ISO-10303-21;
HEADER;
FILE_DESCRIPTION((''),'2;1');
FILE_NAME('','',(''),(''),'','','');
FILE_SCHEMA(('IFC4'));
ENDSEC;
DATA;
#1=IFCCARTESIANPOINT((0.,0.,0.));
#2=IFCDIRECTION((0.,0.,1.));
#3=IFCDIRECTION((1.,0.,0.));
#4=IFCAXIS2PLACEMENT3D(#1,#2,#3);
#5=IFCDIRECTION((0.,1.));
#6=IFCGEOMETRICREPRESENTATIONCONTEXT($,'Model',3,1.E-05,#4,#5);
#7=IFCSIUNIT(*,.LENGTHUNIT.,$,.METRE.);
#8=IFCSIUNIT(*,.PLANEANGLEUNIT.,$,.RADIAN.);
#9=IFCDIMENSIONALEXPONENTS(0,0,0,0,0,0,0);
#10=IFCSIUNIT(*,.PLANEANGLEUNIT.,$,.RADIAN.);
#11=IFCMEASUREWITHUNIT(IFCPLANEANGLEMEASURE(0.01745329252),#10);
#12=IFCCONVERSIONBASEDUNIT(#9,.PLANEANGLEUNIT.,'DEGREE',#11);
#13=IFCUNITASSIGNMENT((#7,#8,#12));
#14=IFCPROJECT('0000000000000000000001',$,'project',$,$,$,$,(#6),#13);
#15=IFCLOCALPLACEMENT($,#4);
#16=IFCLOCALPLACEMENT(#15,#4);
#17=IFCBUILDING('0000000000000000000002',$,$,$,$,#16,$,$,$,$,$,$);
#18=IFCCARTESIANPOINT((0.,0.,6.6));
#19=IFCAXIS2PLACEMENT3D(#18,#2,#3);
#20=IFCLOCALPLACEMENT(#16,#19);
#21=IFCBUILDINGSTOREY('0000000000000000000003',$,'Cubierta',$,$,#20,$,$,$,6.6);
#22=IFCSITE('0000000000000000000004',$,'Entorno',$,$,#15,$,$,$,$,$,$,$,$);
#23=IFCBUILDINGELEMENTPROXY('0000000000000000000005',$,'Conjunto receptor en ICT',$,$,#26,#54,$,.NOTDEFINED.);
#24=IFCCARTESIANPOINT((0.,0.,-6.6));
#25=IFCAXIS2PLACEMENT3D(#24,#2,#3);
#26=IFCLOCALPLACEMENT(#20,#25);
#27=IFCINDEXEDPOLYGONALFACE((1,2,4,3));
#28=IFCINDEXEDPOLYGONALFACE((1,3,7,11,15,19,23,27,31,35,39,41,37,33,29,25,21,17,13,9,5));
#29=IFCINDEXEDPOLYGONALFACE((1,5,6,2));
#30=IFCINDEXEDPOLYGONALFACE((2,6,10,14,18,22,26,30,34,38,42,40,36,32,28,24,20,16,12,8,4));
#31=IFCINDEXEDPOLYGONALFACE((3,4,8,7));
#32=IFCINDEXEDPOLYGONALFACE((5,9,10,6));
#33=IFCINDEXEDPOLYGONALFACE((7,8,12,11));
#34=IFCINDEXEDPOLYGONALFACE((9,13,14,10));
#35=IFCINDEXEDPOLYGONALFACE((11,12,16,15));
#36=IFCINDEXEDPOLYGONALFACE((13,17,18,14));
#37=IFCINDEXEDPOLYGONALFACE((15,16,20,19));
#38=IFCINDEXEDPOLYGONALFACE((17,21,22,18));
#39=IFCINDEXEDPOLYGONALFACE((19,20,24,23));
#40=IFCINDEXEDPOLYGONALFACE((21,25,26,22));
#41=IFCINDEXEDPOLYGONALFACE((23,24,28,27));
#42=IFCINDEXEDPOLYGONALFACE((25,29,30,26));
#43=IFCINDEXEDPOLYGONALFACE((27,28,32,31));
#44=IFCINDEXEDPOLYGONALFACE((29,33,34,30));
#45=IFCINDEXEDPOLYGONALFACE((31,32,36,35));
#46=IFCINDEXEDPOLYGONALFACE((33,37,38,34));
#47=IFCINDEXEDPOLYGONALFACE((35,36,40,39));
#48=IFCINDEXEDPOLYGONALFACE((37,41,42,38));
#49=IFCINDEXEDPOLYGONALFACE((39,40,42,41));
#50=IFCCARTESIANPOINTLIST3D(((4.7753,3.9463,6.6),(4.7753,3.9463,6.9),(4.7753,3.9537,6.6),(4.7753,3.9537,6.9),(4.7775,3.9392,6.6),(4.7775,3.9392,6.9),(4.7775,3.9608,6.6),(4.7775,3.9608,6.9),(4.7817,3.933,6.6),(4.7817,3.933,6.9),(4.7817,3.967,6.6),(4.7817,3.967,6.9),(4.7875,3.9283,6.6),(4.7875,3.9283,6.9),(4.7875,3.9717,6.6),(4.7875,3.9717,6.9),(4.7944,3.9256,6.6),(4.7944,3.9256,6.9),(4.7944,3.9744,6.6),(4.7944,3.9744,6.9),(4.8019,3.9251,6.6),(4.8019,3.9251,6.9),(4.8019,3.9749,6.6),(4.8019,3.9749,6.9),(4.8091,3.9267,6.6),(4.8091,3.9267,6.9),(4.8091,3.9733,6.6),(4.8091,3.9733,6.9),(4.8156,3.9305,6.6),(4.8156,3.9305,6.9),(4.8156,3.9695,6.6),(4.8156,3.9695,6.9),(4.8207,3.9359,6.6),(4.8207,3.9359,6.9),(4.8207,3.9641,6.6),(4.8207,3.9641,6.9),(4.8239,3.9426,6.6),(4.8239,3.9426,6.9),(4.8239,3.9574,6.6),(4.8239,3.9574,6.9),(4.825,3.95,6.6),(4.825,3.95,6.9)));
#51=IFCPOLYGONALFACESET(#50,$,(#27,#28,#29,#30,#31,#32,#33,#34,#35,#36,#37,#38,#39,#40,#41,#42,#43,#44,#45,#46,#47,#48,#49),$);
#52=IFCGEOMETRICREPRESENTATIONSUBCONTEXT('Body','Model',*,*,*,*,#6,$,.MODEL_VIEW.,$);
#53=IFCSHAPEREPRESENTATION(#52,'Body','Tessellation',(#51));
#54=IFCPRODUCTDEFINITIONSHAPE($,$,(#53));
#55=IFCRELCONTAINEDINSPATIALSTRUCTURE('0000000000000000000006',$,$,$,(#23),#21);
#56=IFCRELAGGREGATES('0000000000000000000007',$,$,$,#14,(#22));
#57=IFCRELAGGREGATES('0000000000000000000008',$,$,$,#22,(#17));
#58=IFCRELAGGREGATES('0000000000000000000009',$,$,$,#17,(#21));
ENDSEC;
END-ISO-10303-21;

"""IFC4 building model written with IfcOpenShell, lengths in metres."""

from ifc_helpers import new_model, entity, si_unit, converted_unit, direction, frame, origin_with_axes, place, context, subcontext, project, spatial, element, save


model = new_model("IFC4")

# Units and contexts
model_context = context("Model", 3, precision=1e-05, world=origin_with_axes(), true_north=direction((0.0, 1.0)))
body_context = subcontext(model_context, "Body", "Model", "MODEL_VIEW")
ifc_project = project(units=[si_unit("LENGTHUNIT", "METRE"), si_unit("PLANEANGLEUNIT", "RADIAN"), converted_unit("PLANEANGLEUNIT", "DEGREE", entity("IfcPlaneAngleMeasure", 0.01745329252), si_unit("PLANEANGLEUNIT", "RADIAN"), dimensions=[0, 0, 0, 0, 0, 0, 0])], contexts=[model_context])

# Site, building, storey
site_placement = place(None, origin_with_axes())
site = spatial("IfcSite", under=ifc_project, at=site_placement, Name="Entorno")
building_placement = place(site_placement, origin_with_axes())
building = spatial("IfcBuilding", under=site, at=building_placement)
storey_placement = place(building_placement, frame((0.0, 0.0, 6.6), z_axis=(0.0, 0.0, 1.0), x_axis=(1.0, 0.0, 0.0)))
storey = spatial("IfcBuildingStorey", under=building, at=storey_placement, Name="Cubierta", Elevation=6.6)

# Building element proxy
proxy_1_placement = place(storey_placement, frame((0.0, 0.0, -6.6), z_axis=(0.0, 0.0, 1.0), x_axis=(1.0, 0.0, 0.0)))
ifc_direction = entity("IfcDirection", [0.0, 0.0, 1.0])
element("IfcBuildingElementProxy", 1, at=proxy_1_placement, inside=storey, Name="Conjunto receptor en ICT", PredefinedType="NOTDEFINED", context=body_context, shape_type="Brep", body=[
    entity("IfcExtrudedAreaSolidTapered", entity("IfcCircleProfileDef", "AREA", None, entity("IfcAxis2Placement2D", entity("IfcCartesianPoint", [0.0, 0.0]), entity("IfcDirection", [1.0, 0.0])), 0.025), entity("IfcAxis2Placement3D", entity("IfcCartesianPoint", [4.8, 3.95, 6.6]), ifc_direction, entity("IfcDirection", [1.0, 0.0, 0.0])), ifc_direction, 0.3, entity("IfcCircleProfileDef", "AREA", None, entity("IfcAxis2Placement2D", entity("IfcCartesianPoint", [0.0, 0.0]), entity("IfcDirection", [1.0, 0.0])), 0.025)),
])

save(model, "model.ifc")
